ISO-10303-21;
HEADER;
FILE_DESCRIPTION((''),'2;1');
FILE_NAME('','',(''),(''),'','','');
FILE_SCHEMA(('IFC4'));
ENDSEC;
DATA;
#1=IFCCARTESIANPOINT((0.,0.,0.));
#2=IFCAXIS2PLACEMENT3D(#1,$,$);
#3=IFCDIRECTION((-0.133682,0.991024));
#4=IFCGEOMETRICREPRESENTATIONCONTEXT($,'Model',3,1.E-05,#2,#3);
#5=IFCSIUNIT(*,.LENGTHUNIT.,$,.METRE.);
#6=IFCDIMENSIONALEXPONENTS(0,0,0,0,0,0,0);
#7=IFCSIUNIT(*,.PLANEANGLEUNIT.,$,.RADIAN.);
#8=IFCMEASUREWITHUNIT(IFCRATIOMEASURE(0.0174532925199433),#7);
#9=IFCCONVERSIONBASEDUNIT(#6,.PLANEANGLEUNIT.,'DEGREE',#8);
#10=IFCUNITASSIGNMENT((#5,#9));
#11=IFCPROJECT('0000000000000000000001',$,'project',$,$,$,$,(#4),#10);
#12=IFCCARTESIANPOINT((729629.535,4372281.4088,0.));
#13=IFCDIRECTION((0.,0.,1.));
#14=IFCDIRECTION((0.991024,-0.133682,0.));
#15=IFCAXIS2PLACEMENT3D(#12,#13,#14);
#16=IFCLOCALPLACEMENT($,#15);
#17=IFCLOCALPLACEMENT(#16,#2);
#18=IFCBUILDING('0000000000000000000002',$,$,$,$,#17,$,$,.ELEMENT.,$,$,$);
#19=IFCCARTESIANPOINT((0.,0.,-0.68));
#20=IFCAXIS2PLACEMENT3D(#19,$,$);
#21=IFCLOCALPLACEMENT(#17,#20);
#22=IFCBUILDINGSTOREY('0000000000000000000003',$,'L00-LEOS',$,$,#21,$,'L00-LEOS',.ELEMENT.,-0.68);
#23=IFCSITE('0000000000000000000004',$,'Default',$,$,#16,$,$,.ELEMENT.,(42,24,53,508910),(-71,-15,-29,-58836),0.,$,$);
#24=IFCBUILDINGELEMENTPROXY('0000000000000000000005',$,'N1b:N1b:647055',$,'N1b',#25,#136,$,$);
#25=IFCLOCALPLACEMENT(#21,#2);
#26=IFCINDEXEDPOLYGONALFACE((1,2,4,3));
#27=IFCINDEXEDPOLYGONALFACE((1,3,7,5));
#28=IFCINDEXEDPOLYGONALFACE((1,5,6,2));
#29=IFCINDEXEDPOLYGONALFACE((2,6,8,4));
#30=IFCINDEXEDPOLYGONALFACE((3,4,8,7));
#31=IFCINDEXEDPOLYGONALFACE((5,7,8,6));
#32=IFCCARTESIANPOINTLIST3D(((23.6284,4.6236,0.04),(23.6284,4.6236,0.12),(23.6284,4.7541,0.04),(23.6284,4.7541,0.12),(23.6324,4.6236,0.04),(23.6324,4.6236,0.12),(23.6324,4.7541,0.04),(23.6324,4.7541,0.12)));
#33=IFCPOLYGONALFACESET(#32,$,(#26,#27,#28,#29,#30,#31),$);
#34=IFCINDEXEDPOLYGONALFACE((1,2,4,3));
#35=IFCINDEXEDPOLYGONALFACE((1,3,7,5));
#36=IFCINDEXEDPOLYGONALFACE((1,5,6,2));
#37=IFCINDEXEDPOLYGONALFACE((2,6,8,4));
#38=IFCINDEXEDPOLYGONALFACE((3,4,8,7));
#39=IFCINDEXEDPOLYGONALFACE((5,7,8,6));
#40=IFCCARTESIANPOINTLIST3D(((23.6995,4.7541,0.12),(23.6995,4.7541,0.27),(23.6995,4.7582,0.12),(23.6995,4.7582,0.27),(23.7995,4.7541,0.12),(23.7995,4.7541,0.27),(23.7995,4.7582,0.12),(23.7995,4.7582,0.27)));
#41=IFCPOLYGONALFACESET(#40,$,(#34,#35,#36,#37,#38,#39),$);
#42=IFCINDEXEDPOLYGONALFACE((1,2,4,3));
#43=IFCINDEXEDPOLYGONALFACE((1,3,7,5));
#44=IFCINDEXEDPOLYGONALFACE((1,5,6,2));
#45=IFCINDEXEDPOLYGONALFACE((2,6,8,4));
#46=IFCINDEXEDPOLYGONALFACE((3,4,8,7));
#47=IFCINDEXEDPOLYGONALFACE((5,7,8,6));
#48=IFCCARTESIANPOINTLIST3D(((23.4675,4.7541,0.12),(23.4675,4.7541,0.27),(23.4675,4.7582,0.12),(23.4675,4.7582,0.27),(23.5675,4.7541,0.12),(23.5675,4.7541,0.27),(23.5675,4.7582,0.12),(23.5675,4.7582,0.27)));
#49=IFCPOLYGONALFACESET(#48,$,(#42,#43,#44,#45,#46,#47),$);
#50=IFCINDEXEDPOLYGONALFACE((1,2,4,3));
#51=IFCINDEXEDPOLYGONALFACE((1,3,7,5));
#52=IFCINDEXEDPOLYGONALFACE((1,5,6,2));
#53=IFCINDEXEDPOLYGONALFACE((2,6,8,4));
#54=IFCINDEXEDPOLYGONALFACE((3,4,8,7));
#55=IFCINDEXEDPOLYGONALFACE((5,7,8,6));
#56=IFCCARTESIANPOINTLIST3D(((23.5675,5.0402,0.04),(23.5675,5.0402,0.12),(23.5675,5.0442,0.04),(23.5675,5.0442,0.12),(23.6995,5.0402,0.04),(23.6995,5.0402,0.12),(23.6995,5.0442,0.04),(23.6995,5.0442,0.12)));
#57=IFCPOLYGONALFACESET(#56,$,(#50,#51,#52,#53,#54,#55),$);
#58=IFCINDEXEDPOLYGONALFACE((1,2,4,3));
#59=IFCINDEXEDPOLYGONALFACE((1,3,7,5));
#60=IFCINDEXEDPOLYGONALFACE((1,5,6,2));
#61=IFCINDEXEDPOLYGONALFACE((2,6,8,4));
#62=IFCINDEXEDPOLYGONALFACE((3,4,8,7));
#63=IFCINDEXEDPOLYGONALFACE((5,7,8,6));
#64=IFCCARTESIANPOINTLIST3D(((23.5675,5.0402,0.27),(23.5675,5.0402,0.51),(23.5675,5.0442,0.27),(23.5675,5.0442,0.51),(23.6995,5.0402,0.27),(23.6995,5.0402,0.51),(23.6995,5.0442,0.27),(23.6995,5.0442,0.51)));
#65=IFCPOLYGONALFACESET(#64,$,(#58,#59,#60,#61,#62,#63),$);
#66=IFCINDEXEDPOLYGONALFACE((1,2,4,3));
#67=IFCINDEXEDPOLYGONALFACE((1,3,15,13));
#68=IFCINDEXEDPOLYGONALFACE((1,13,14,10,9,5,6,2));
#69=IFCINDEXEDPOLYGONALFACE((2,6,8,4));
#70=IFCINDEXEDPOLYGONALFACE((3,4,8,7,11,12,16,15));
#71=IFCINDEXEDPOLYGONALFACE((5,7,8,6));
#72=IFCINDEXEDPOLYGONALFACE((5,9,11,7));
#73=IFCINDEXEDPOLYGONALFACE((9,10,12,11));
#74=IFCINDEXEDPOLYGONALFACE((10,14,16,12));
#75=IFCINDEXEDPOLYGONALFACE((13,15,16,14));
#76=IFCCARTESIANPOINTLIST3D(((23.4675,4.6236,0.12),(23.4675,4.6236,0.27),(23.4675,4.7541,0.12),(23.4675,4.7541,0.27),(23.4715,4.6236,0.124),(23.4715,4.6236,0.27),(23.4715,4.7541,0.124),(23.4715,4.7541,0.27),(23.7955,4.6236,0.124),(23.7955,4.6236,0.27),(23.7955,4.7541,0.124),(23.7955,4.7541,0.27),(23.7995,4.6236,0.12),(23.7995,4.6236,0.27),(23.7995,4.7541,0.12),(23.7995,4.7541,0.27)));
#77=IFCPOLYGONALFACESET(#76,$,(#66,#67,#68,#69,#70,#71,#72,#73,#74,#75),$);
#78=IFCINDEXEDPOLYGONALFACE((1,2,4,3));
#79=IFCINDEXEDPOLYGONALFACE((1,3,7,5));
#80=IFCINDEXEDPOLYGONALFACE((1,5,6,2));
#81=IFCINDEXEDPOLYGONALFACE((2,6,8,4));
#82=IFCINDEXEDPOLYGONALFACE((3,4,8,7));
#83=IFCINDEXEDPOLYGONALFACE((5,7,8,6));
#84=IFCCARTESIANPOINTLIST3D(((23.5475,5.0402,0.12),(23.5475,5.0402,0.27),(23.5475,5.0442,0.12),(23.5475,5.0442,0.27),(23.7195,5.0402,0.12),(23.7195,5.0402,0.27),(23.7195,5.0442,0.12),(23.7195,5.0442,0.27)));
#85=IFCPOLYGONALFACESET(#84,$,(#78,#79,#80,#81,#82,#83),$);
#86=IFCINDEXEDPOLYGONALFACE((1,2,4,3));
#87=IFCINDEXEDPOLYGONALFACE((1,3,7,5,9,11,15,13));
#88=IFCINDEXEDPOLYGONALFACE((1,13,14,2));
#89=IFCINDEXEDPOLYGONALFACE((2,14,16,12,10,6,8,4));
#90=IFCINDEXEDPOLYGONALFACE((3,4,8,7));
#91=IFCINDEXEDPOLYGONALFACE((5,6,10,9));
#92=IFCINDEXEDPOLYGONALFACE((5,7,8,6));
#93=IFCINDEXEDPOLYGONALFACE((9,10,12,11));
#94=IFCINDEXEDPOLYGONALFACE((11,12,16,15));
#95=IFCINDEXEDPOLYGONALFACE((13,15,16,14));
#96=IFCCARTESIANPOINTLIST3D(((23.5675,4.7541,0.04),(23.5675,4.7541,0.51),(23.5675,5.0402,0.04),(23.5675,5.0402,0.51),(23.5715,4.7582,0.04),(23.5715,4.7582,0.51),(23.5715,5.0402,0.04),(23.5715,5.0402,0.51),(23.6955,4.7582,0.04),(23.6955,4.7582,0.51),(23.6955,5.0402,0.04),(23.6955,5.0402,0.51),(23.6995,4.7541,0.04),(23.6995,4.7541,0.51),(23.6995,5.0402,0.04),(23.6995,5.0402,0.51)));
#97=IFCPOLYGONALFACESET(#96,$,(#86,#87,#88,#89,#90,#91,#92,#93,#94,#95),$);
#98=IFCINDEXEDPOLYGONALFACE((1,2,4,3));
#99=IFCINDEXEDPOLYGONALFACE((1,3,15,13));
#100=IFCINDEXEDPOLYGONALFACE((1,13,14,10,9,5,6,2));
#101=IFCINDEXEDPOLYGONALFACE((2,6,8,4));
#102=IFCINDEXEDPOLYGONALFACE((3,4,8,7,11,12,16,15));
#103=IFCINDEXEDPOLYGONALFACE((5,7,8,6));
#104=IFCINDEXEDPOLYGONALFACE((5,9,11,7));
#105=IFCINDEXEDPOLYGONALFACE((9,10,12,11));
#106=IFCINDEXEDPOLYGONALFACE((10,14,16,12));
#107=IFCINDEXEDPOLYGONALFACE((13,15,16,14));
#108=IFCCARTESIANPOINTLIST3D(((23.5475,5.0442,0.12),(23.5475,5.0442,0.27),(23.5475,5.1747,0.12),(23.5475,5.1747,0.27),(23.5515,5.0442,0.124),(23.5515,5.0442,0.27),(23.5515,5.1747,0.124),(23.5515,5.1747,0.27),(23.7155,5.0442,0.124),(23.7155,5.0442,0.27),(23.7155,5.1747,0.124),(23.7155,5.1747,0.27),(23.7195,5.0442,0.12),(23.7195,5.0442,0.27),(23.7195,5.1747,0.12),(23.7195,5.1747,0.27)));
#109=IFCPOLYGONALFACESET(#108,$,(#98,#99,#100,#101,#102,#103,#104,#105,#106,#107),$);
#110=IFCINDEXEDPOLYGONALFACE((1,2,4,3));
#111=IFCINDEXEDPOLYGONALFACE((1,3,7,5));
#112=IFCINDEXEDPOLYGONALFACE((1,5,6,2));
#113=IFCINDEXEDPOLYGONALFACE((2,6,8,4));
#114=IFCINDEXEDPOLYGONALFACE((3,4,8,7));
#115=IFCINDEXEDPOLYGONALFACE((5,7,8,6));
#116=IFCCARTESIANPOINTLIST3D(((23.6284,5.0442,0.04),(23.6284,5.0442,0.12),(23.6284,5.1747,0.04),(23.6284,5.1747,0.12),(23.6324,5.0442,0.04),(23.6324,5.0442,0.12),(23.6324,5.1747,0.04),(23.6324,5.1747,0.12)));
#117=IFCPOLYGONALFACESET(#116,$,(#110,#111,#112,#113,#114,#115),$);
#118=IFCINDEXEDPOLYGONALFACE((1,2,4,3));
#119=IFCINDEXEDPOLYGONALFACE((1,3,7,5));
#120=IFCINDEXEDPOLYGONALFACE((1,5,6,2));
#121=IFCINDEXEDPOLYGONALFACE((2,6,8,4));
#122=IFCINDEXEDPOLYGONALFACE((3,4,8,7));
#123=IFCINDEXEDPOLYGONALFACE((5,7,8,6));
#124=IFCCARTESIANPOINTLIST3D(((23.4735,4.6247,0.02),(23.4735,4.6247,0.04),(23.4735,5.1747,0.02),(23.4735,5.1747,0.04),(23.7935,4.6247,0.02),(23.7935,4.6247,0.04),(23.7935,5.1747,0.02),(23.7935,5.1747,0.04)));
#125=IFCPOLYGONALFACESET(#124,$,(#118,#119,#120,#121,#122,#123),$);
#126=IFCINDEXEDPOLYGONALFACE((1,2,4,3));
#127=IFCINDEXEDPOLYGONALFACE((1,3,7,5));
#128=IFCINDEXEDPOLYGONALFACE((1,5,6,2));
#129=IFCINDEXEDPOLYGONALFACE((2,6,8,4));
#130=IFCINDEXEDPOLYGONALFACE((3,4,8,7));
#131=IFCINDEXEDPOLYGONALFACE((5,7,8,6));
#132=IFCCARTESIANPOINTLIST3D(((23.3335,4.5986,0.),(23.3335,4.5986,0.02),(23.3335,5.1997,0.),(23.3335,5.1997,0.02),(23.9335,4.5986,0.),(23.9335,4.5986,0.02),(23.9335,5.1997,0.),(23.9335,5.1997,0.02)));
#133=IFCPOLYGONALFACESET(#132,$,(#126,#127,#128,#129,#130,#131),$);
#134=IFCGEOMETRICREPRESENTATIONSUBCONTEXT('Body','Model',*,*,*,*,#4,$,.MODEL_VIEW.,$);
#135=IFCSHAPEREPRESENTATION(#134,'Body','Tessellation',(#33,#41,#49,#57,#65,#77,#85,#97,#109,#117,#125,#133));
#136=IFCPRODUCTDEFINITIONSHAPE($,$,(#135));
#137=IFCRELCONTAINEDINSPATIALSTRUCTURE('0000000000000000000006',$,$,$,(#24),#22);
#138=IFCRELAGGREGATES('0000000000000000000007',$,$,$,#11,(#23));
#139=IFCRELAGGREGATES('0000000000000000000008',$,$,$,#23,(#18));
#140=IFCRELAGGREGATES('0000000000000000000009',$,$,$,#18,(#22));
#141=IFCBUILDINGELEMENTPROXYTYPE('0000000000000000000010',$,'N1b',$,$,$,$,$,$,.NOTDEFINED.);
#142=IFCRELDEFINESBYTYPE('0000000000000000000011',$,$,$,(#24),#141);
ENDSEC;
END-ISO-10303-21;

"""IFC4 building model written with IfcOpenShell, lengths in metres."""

from ifc_helpers import new_model, entity, si_unit, converted_unit, direction, frame, frame_2d, origin, origin_2d_with_axis, place, context, subcontext, project, spatial, polyline, rectangle, outline, extrude, source, transform, mapped, type_object, type_shapes, element, save


model = new_model("IFC4")

# Units and contexts
model_context = context("Model", 3, precision=1e-05, world=origin(), true_north=direction((-0.133682, 0.991024)))
body_context = subcontext(model_context, "Body", "Model", "MODEL_VIEW")
ifc_project = project(units=[si_unit("LENGTHUNIT", "METRE"), converted_unit("PLANEANGLEUNIT", "DEGREE", entity("IfcRatioMeasure", 0.0174532925199433), si_unit("PLANEANGLEUNIT", "RADIAN"), dimensions=[0, 0, 0, 0, 0, 0, 0])], contexts=[model_context])

# Site, building, storey
site_placement = place(None, frame((729629.535, 4372281.4088, 0.0), z_axis=(0.0, 0.0, 1.0), x_axis=(0.991024, -0.133682, 0.0)))
site = spatial("IfcSite", under=ifc_project, at=site_placement, Name="Default", CompositionType="ELEMENT", RefLatitude=(42, 24, 53, 508910), RefLongitude=(-71, -15, -29, -58836), RefElevation=0.0)
building_placement = place(site_placement, origin())
building = spatial("IfcBuilding", under=site, at=building_placement, CompositionType="ELEMENT")
storey_placement = place(building_placement, frame((0.0, 0.0, -0.68)))
storey = spatial("IfcBuildingStorey", under=building, at=storey_placement, Name="L00-LEOS", LongName="L00-LEOS", CompositionType="ELEMENT", Elevation=-0.68)

# Building element proxy
building_element_proxy_type_1 = type_object("IfcBuildingElementProxyType", Name="N1b")
shared_shape_1 = source(origin(), body_context, "Body", "SweptSolid", [
    extrude(rectangle(XDim=0.004, YDim=0.1305, at=origin_2d_with_axis()), frame((0.2103, 0.0, 0.04), z_axis=(0.0, 0.0, 1.0), x_axis=(0.0, -1.0, 0.0)), (0.0, 0.0, 1.0), 0.08),
    extrude(rectangle(XDim=0.1, YDim=0.0042, at=frame_2d((0.0, 0.0), x_axis=(1.0, 0.0))), frame((0.143, 0.1191, 0.12), z_axis=(0.0, 0.0, 1.0), x_axis=(0.0, 1.0, 0.0)), (0.0, 0.0, 1.0), 0.15),
    extrude(rectangle(XDim=0.1, YDim=0.0042, at=origin_2d_with_axis()), frame((0.143, -0.1129, 0.12), z_axis=(0.0, 0.0, 1.0), x_axis=(0.0, 1.0, 0.0)), (0.0, 0.0, 1.0), 0.15),
    extrude(rectangle(XDim=0.132, YDim=0.004, at=frame_2d((0.0, 0.0), x_axis=(1.0, 0.0))), frame((-0.1431, 0.0031, 0.04), z_axis=(0.0, 0.0, 1.0), x_axis=(0.0, 1.0, 0.0)), (0.0, 0.0, 1.0), 0.08),
    extrude(rectangle(XDim=0.132, YDim=0.004, at=frame_2d((0.0, 0.0), x_axis=(1.0, 0.0))), frame((-0.1431, 0.0031, 0.27), z_axis=(0.0, 0.0, 1.0), x_axis=(0.0, 1.0, 0.0)), (0.0, 0.0, 1.0), 0.24),
    extrude(outline(polyline([(-0.076, -0.166), (0.074, -0.166), (0.074, -0.162), (-0.072, -0.162), (-0.072, 0.162), (0.074, 0.162), (0.074, 0.166), (-0.076, 0.166), (-0.076, -0.166)])), frame((0.1451, 0.0031, 0.196), z_axis=(1.0, 0.0, 0.0), x_axis=(0.0, 0.0, 1.0)), (0.0, 0.0, 1.0), 0.1305),
    extrude(rectangle(XDim=0.172, YDim=0.004, at=frame_2d((0.0, 0.0), x_axis=(1.0, 0.0))), frame((-0.1431, 0.0031, 0.12), z_axis=(0.0, 0.0, 1.0), x_axis=(0.0, 1.0, 0.0)), (0.0, 0.0, 1.0), 0.15),
    extrude(outline(polyline([(-0.1441, -0.066), (0.142, -0.066), (0.142, -0.062), (-0.14, -0.062), (-0.14, 0.062), (0.142, 0.062), (0.142, 0.066), (-0.1441, 0.066), (-0.1441, -0.066)])), frame((0.001, 0.0031, 0.04), z_axis=(0.0, 0.0, 1.0), x_axis=(-1.0, 0.0, 0.0)), (0.0, 0.0, 1.0), 0.47),
    extrude(outline(polyline([(-0.076, -0.086), (0.074, -0.086), (0.074, -0.082), (-0.072, -0.082), (-0.072, 0.082), (0.074, 0.082), (0.074, 0.086), (-0.076, 0.086), (-0.076, -0.086)])), frame((-0.2756, 0.0031, 0.196), z_axis=(1.0, 0.0, 0.0), x_axis=(0.0, 0.0, 1.0)), (0.0, 0.0, 1.0), 0.1305),
    extrude(rectangle(XDim=0.004, YDim=0.1305, at=origin_2d_with_axis()), frame((-0.2103, 0.0, 0.04), z_axis=(0.0, 0.0, 1.0), x_axis=(0.0, -1.0, 0.0)), (0.0, 0.0, 1.0), 0.08),
    extrude(rectangle(XDim=0.55, YDim=0.32, at=frame_2d((0.0, 0.0), x_axis=(1.0, 0.0))), frame((-0.0006, 0.0031, 0.02), z_axis=(0.0, 0.0, 1.0), x_axis=(-1.0, 0.0, 0.0)), (0.0, 0.0, 1.0), 0.02),
    extrude(rectangle(XDim=0.6012, YDim=0.6, at=frame_2d((0.0, 0.0), x_axis=(1.0, 0.0))), frame((0.0, 0.0031, 0.0), z_axis=(0.0, 0.0, 1.0), x_axis=(-1.0, 0.0, 0.0)), (0.0, 0.0, 1.0), 0.02),
])
type_shapes(building_element_proxy_type_1, [shared_shape_1])
for number, where, z_axis, x_axis, name in (
    (1, (23.6304, 4.8991, 0.0), (0.0, 0.0, 1.0), (0.0, -1.0, 0.0), "N1b:N1b:647055"),
):
    element("IfcBuildingElementProxy", number, at=place(storey_placement, frame(where, z_axis=z_axis, x_axis=x_axis)), inside=storey, type_object=building_element_proxy_type_1, Name=name, ObjectType="N1b", context=body_context, shape_type="MappedRepresentation", body=[
        mapped(shared_shape_1, transform((0.0, 0.0, 0.0), scale=1.0)),
    ])

save(model, "model.ifc")
